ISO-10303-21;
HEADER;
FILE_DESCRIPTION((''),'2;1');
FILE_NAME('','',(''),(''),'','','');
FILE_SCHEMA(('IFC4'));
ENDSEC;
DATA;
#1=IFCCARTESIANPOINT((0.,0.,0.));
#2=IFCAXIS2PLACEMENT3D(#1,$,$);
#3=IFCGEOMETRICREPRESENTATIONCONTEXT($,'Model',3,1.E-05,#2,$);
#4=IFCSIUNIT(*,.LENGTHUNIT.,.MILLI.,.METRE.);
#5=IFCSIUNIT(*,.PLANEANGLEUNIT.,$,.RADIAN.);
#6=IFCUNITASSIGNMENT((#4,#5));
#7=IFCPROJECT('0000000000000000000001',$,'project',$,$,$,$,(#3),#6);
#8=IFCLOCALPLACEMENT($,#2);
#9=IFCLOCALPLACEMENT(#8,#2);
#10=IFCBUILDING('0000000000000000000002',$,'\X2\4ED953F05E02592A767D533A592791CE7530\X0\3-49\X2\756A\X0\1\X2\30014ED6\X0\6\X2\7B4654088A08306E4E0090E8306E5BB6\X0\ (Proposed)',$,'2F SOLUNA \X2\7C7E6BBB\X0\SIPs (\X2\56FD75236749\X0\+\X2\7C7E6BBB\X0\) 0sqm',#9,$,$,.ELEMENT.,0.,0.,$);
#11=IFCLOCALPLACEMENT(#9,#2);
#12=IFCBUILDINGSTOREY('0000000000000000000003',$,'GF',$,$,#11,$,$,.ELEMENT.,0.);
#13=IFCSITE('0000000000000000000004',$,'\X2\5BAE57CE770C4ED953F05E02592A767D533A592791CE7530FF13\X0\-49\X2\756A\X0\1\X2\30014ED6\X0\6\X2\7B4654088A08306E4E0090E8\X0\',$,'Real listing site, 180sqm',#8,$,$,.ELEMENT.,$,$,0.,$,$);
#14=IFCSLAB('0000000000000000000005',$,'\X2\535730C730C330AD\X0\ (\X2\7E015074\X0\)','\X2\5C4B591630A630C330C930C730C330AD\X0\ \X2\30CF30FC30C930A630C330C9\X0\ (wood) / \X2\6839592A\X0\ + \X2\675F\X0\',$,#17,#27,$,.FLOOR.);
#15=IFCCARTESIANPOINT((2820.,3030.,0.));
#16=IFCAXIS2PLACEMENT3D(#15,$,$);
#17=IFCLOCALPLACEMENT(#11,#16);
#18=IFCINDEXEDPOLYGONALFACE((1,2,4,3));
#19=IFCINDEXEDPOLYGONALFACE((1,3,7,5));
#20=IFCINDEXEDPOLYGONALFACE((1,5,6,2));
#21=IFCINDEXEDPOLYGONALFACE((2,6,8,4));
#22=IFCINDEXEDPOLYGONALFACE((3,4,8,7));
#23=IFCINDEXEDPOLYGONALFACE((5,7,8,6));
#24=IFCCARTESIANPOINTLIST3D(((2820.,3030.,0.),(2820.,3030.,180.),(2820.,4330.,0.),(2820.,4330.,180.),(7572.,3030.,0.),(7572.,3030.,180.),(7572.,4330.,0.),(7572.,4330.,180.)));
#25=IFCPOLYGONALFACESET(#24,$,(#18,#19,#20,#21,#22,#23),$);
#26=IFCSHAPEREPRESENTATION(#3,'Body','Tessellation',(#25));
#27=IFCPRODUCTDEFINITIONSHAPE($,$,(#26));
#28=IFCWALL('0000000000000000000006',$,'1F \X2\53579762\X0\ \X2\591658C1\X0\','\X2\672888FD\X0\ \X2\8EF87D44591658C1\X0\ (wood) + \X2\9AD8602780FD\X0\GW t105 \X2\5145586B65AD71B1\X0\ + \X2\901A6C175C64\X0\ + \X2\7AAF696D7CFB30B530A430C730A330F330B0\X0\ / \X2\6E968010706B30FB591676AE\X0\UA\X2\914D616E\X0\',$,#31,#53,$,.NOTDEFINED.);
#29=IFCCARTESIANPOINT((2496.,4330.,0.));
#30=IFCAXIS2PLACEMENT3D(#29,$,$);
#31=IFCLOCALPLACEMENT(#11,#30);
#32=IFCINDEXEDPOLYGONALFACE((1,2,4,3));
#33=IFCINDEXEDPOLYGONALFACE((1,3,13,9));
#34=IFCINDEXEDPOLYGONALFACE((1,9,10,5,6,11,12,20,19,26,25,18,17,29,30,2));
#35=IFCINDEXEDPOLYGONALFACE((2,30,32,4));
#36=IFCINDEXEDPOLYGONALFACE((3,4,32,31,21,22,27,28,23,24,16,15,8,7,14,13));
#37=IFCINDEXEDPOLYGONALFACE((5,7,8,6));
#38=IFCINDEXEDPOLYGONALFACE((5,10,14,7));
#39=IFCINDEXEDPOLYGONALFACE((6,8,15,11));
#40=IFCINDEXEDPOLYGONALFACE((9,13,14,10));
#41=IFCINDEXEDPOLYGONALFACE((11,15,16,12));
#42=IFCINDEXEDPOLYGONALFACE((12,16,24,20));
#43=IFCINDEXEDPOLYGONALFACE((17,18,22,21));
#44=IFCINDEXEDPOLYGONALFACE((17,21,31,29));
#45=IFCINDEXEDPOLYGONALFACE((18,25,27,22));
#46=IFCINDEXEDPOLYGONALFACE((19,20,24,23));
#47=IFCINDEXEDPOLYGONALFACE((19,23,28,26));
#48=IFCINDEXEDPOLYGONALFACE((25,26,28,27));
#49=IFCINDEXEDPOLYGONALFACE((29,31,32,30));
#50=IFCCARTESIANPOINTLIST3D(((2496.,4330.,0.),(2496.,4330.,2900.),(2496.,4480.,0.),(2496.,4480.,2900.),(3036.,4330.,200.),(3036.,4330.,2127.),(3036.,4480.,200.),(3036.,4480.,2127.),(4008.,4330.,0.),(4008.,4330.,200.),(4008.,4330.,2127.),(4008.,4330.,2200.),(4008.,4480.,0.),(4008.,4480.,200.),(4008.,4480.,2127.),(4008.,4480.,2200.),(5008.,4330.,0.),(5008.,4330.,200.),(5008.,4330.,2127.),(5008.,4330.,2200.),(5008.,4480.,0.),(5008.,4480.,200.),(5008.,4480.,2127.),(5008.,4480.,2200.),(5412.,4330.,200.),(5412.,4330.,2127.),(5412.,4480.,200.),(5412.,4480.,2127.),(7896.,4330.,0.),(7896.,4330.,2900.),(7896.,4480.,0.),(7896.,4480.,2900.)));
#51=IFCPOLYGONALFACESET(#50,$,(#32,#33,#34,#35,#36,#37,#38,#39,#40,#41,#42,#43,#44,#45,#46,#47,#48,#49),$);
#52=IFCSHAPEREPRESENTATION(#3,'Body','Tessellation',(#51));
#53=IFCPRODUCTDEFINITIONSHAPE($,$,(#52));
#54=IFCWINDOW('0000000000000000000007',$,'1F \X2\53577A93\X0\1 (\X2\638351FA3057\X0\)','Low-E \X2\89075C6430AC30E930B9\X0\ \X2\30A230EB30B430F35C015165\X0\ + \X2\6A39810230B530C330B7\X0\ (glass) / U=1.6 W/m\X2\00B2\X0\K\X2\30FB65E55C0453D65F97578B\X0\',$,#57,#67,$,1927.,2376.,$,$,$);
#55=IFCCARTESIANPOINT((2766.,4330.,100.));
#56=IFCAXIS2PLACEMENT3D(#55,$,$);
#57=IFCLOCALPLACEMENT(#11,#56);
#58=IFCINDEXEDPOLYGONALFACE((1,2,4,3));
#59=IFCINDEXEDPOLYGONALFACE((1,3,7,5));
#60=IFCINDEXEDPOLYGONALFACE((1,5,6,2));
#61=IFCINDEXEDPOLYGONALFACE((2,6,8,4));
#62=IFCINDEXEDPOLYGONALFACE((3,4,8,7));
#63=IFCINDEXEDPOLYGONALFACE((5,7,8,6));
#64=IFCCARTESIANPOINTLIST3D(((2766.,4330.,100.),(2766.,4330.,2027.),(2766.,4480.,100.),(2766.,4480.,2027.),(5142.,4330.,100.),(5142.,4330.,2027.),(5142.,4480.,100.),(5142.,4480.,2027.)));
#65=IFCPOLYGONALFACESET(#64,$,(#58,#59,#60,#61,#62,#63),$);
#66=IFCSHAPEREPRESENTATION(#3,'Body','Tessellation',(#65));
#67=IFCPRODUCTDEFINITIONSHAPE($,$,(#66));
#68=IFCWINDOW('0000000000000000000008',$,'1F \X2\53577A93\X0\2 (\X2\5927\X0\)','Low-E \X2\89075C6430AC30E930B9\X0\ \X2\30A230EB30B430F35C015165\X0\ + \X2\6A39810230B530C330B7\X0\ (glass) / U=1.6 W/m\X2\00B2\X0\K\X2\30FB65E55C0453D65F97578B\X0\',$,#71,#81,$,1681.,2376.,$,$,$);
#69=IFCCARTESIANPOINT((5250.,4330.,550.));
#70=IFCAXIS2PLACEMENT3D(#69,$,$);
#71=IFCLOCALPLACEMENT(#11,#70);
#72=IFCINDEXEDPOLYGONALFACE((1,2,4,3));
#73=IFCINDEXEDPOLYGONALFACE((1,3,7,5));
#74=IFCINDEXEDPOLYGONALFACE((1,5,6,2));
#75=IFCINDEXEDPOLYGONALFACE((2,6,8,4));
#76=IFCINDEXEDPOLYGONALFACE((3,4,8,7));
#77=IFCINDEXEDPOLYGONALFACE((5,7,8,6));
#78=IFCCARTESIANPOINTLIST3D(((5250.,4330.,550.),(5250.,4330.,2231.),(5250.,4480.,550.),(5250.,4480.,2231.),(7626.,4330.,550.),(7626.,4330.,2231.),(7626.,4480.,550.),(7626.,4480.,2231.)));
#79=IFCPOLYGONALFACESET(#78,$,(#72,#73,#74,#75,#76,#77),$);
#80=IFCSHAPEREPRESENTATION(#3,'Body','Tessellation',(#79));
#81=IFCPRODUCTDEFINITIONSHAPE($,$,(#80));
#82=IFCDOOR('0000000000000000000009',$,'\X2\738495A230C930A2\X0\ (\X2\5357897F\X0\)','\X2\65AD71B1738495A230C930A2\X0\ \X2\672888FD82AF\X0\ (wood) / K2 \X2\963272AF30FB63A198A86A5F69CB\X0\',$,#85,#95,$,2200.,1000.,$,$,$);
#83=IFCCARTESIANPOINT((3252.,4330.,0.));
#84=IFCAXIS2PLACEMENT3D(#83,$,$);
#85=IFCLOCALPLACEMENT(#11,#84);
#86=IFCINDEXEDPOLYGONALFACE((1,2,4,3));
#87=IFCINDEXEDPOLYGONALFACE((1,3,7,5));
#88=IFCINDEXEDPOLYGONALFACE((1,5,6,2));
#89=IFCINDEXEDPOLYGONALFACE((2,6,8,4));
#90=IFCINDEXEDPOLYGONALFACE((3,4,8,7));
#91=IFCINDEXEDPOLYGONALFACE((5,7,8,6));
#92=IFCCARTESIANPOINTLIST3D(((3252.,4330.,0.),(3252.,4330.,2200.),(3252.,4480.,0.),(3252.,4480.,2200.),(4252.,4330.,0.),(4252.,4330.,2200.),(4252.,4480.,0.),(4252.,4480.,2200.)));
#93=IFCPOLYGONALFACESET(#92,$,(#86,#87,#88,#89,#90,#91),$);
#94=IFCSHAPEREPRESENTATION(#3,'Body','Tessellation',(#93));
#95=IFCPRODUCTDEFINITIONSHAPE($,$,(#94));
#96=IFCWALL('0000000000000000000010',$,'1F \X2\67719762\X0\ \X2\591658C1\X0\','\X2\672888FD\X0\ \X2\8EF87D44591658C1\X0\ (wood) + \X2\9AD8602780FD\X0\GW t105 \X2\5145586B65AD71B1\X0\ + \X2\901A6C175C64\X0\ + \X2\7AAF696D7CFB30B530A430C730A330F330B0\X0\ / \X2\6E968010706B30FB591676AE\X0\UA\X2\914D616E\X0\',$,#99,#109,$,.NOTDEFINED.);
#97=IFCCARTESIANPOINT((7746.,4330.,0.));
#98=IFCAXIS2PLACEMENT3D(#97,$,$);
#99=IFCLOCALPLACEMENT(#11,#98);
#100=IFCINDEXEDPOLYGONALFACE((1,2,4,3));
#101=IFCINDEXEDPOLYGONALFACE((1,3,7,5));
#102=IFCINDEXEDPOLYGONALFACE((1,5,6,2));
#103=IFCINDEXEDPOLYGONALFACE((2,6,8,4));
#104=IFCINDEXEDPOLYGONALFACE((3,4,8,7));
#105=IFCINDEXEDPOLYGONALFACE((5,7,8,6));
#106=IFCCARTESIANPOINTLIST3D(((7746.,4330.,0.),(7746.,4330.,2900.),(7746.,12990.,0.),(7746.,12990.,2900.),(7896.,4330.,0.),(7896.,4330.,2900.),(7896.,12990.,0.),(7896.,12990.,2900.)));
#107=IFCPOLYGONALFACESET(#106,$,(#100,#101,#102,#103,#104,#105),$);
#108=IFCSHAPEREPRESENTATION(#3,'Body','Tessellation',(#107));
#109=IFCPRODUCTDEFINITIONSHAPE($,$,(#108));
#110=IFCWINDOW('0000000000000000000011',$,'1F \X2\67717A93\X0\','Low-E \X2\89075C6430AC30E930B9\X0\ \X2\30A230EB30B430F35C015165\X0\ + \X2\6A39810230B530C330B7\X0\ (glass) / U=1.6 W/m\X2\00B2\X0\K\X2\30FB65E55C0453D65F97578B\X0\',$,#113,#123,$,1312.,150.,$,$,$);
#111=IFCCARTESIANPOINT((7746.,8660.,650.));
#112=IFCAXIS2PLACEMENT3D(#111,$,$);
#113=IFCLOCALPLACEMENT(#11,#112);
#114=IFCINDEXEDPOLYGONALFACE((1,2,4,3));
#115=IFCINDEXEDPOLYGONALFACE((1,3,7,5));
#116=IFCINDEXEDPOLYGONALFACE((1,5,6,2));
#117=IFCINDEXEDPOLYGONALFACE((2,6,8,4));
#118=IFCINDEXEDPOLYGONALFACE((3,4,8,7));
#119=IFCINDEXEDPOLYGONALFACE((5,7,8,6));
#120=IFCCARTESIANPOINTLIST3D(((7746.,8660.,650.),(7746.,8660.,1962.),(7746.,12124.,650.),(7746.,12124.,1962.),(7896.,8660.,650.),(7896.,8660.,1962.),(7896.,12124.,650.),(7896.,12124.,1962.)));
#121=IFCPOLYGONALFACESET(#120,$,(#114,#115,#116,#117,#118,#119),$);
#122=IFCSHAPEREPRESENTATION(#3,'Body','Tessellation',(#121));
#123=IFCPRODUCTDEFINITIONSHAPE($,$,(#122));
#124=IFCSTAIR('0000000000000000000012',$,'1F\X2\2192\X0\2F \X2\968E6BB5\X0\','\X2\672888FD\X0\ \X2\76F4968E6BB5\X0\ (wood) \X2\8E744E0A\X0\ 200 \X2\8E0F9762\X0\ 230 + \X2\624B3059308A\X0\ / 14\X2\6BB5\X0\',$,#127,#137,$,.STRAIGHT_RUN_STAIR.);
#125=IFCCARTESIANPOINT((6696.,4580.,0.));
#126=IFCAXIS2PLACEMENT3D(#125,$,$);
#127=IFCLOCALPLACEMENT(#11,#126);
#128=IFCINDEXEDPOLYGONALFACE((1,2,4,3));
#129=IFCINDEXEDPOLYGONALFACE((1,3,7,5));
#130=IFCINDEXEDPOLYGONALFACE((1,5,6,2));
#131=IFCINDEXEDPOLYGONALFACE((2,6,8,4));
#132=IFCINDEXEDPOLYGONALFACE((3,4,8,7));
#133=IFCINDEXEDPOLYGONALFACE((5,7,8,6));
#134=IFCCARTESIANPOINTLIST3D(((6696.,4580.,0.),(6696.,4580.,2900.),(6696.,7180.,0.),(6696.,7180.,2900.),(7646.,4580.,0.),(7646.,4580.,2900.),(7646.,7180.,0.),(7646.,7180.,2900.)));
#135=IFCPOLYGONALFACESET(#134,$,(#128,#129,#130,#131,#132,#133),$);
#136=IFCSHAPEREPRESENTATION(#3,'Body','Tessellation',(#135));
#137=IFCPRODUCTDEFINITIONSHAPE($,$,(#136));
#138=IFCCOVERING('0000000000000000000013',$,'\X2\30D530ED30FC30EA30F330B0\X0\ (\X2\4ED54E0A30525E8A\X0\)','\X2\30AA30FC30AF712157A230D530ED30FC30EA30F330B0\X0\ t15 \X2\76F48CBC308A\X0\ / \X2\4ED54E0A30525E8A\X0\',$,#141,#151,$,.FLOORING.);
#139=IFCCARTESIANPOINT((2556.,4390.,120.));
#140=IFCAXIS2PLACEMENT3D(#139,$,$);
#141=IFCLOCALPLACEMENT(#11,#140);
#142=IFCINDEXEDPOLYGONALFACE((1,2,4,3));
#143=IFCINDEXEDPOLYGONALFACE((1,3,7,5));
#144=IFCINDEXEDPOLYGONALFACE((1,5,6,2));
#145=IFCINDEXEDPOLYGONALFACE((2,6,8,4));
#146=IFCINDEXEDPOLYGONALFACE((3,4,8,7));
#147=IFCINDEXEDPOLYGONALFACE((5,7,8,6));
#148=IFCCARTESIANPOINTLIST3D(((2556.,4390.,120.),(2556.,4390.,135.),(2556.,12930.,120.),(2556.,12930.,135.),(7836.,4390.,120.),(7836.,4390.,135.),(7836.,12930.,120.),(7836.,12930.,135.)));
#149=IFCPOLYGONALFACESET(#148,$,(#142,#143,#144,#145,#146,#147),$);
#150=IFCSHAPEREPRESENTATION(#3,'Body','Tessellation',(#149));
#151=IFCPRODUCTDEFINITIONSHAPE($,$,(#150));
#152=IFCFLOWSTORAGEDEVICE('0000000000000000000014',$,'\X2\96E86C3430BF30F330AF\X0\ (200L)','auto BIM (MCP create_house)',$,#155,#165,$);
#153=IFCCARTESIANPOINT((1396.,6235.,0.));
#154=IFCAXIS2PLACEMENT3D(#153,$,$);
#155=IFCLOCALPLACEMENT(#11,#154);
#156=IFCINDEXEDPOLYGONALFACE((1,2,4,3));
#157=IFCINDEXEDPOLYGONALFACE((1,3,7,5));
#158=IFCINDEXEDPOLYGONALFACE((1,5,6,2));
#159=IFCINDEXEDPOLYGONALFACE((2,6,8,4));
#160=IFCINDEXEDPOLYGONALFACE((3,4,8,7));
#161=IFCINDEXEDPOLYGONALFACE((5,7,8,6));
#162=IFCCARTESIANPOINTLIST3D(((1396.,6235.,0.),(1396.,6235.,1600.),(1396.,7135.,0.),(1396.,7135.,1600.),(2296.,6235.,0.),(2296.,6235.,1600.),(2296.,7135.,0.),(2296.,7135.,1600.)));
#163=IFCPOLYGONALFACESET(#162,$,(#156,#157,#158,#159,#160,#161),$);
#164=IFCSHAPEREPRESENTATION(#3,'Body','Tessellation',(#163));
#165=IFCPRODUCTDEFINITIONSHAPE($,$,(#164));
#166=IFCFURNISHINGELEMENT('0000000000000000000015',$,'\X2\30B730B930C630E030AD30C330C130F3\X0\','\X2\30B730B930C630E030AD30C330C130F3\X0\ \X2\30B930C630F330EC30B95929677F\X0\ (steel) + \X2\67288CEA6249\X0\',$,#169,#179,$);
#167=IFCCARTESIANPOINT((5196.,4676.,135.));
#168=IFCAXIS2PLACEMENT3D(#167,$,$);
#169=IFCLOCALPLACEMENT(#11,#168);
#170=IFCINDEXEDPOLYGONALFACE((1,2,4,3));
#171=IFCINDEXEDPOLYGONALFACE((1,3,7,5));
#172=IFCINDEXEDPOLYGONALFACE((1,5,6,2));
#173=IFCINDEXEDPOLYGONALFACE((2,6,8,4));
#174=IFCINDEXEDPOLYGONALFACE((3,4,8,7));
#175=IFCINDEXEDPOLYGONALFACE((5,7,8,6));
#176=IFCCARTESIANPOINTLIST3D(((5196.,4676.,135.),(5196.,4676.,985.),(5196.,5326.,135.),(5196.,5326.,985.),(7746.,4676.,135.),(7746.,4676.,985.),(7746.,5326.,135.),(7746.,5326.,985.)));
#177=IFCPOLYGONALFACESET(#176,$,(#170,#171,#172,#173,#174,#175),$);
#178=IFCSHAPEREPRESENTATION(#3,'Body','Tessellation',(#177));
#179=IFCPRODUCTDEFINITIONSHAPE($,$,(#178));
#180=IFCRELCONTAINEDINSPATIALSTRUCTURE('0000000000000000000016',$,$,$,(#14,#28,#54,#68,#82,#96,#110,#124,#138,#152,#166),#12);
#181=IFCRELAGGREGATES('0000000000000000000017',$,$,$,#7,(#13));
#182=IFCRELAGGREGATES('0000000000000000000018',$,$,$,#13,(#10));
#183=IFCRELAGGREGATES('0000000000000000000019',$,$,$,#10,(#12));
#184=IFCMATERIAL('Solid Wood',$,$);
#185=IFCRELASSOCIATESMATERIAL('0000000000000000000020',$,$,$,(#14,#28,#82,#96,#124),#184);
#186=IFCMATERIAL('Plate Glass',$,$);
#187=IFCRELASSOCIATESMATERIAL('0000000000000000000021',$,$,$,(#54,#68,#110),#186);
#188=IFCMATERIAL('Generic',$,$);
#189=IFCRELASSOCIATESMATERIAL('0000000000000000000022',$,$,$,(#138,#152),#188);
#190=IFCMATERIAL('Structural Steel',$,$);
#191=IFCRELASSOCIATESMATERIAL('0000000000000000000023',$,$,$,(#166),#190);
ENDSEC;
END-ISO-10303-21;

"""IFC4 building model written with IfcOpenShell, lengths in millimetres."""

from ifc_helpers import new_model, si_unit, frame, frame_2d, origin, place, context, project, spatial, rectangle, extrude, material, element, fill, save


model = new_model("IFC4")

# Units and contexts
model_context = context("Model", 3, precision=1e-05, world=origin())
ifc_project = project(units=[si_unit("LENGTHUNIT", "METRE", prefix="MILLI"), si_unit("PLANEANGLEUNIT", "RADIAN")], contexts=[model_context])

# Site, building, storey
site_placement = place(None, origin())
site = spatial("IfcSite", under=ifc_project, at=site_placement, Name="宮城県仙台市太白区大野田３-49番1、他6筆合計の一部", ObjectType="Real listing site, 180sqm", CompositionType="ELEMENT", RefElevation=0.0)
building_placement = place(site_placement, origin())
building = spatial("IfcBuilding", under=site, at=building_placement, Name="仙台市太白区大野田3-49番1、他6筆合計の一部の家 (Proposed)", ObjectType="2F SOLUNA 籾殻SIPs (国産杉+籾殻) 0sqm", CompositionType="ELEMENT", ElevationOfRefHeight=0.0, ElevationOfTerrain=0.0)
storey_placement = place(building_placement, origin())
storey = spatial("IfcBuildingStorey", under=building, at=storey_placement, Name="GF", CompositionType="ELEMENT", Elevation=0.0)

# Slab
ifc_material_1 = material(Name="Solid Wood")
slab_1_placement = place(storey_placement, frame((2820.0, 3030.0, 0.0)))
element("IfcSlab", 1, at=slab_1_placement, inside=storey, material=ifc_material_1, Name="南デッキ (縁側)", Description="屋外ウッドデッキ ハードウッド (wood) / 根太 + 束", PredefinedType="FLOOR", context=model_context, shape_type="SweptSolid", body=[
    extrude(rectangle(XDim=4752.0, YDim=1300.0, at=frame_2d((2376.0, 650.0))), frame((2820.0, 3030.0, 0.0)), (0.0, 0.0, 1.0), 180.0),
])

# Wall, openings, windows, door
wall_1_placement = place(storey_placement, frame((2496.0, 4330.0, 0.0)))
wall_1 = element("IfcWall", 2, at=wall_1_placement, inside=storey, material=ifc_material_1, Name="1F 南面 外壁", Description="木製 軸組外壁 (wood) + 高性能GW t105 充填断熱 + 通気層 + 窯業系サイディング / 準耐火・外皮UA配慮", PredefinedType="NOTDEFINED", context=model_context, shape_type="SweptSolid", body=[
    extrude(rectangle(XDim=5400.0, YDim=150.0, at=frame_2d((2700.0, 75.0))), frame((2496.0, 4330.0, 0.0)), (0.0, 0.0, 1.0), 2900.0),
])
opening_1_placement = place(storey_placement, frame((2766.0, 4330.0, 100.0)))
opening_1 = element("IfcOpeningElement", 3, at=opening_1_placement, cuts=wall_1, PredefinedType="NOTDEFINED", context=model_context, shape_type="SweptSolid", body=[
    extrude(rectangle(XDim=2376.0, YDim=150.0, at=frame_2d((1188.0, 75.0))), frame((2766.0, 4330.0, 100.0)), (0.0, 0.0, 1.0), 1927.0),
])
opening_2_placement = place(storey_placement, frame((5250.0, 4330.0, 550.0)))
opening_2 = element("IfcOpeningElement", 4, at=opening_2_placement, cuts=wall_1, PredefinedType="NOTDEFINED", context=model_context, shape_type="SweptSolid", body=[
    extrude(rectangle(XDim=2376.0, YDim=150.0, at=frame_2d((1188.0, 75.0))), frame((5250.0, 4330.0, 550.0)), (0.0, 0.0, 1.0), 1681.0),
])
opening_3_placement = place(storey_placement, frame((3252.0, 4330.0, 0.0)))
opening_3 = element("IfcOpeningElement", 5, at=opening_3_placement, cuts=wall_1, PredefinedType="NOTDEFINED", context=model_context, shape_type="SweptSolid", body=[
    extrude(rectangle(XDim=1000.0, YDim=150.0, at=frame_2d((500.0, 75.0))), frame((3252.0, 4330.0, 0.0)), (0.0, 0.0, 1.0), 2200.0),
])
ifc_material_2 = material(Name="Plate Glass")
window_1_placement = place(storey_placement, frame((2766.0, 4330.0, 100.0)))
window_1 = element("IfcWindow", 6, at=window_1_placement, inside=storey, material=ifc_material_2, Name="1F 南窓1 (掃出し)", Description="Low-E 複層ガラス アルゴン封入 + 樹脂サッシ (glass) / U=1.6 W/m²K・日射取得型", OverallHeight=1927.0, OverallWidth=2376.0, context=model_context, shape_type="SweptSolid", body=[
    extrude(rectangle(XDim=2376.0, YDim=150.0, at=frame_2d((1188.0, 75.0))), frame((2766.0, 4330.0, 100.0)), (0.0, 0.0, 1.0), 1927.0),
])
fill(opening_1, window_1)
window_2_placement = place(storey_placement, frame((5250.0, 4330.0, 550.0)))
window_2 = element("IfcWindow", 7, at=window_2_placement, inside=storey, material=ifc_material_2, Name="1F 南窓2 (大)", Description="Low-E 複層ガラス アルゴン封入 + 樹脂サッシ (glass) / U=1.6 W/m²K・日射取得型", OverallHeight=1681.0, OverallWidth=2376.0, context=model_context, shape_type="SweptSolid", body=[
    extrude(rectangle(XDim=2376.0, YDim=150.0, at=frame_2d((1188.0, 75.0))), frame((5250.0, 4330.0, 550.0)), (0.0, 0.0, 1.0), 1681.0),
])
fill(opening_2, window_2)
door_placement = place(storey_placement, frame((3252.0, 4330.0, 0.0)))
door = element("IfcDoor", 8, at=door_placement, inside=storey, material=ifc_material_1, Name="玄関ドア (南西)", Description="断熱玄関ドア 木製芯 (wood) / K2 防犯・採風機構", OverallHeight=2200.0, OverallWidth=1000.0, context=model_context, shape_type="SweptSolid", body=[
    extrude(rectangle(XDim=1000.0, YDim=150.0, at=frame_2d((500.0, 75.0))), frame((3252.0, 4330.0, 0.0)), (0.0, 0.0, 1.0), 2200.0),
])
fill(opening_3, door)

# Wall, opening, window
wall_2_placement = place(storey_placement, frame((7746.0, 4330.0, 0.0)))
wall_2 = element("IfcWall", 9, at=wall_2_placement, inside=storey, material=ifc_material_1, Name="1F 東面 外壁", Description="木製 軸組外壁 (wood) + 高性能GW t105 充填断熱 + 通気層 + 窯業系サイディング / 準耐火・外皮UA配慮", PredefinedType="NOTDEFINED", context=model_context, shape_type="SweptSolid", body=[
    extrude(rectangle(XDim=150.0, YDim=8660.0, at=frame_2d((75.0, 4330.0))), frame((7746.0, 4330.0, 0.0)), (0.0, 0.0, 1.0), 2900.0),
])
opening_4_placement = place(storey_placement, frame((7746.0, 8660.0, 650.0)))
opening_4 = element("IfcOpeningElement", 10, at=opening_4_placement, cuts=wall_2, PredefinedType="NOTDEFINED", context=model_context, shape_type="SweptSolid", body=[
    extrude(rectangle(XDim=150.0, YDim=3464.0, at=frame_2d((75.0, 1732.0))), frame((7746.0, 8660.0, 650.0)), (0.0, 0.0, 1.0), 1312.0),
])
window_3_placement = place(storey_placement, frame((7746.0, 8660.0, 650.0)))
window_3 = element("IfcWindow", 11, at=window_3_placement, inside=storey, material=ifc_material_2, Name="1F 東窓", Description="Low-E 複層ガラス アルゴン封入 + 樹脂サッシ (glass) / U=1.6 W/m²K・日射取得型", OverallHeight=1312.0, OverallWidth=150.0, context=model_context, shape_type="SweptSolid", body=[
    extrude(rectangle(XDim=150.0, YDim=3464.0, at=frame_2d((75.0, 1732.0))), frame((7746.0, 8660.0, 650.0)), (0.0, 0.0, 1.0), 1312.0),
])
fill(opening_4, window_3)

# Stair
stair_placement = place(storey_placement, frame((6696.0, 4580.0, 0.0)))
element("IfcStair", 12, at=stair_placement, inside=storey, material=ifc_material_1, Name="1F→2F 階段", Description="木製 直階段 (wood) 蹴上 200 踏面 230 + 手すり / 14段", PredefinedType="STRAIGHT_RUN_STAIR", context=model_context, shape_type="SweptSolid", body=[
    extrude(rectangle(XDim=950.0, YDim=2600.0, at=frame_2d((475.0, 1300.0))), frame((6696.0, 4580.0, 0.0)), (0.0, 0.0, 1.0), 2900.0),
])

# Covering
ifc_material_3 = material(Name="Generic")
covering_placement = place(storey_placement, frame((2556.0, 4390.0, 120.0)))
element("IfcCovering", 13, at=covering_placement, inside=storey, material=ifc_material_3, Name="フローリング (仕上げ床)", Description="オーク無垢フローリング t15 直貼り / 仕上げ床", PredefinedType="FLOORING", context=model_context, shape_type="SweptSolid", body=[
    extrude(rectangle(XDim=5280.0, YDim=8540.0, at=frame_2d((2640.0, 4270.0))), frame((2556.0, 4390.0, 120.0)), (0.0, 0.0, 1.0), 15.0),
])

# Flow storage device
flow_storage_device_placement = place(storey_placement, frame((1396.0, 6235.0, 0.0)))
element("IfcFlowStorageDevice", 14, at=flow_storage_device_placement, inside=storey, material=ifc_material_3, Name="雨水タンク (200L)", Description="auto BIM (MCP create_house)", context=model_context, shape_type="SweptSolid", body=[
    extrude(rectangle(XDim=900.0, YDim=900.0, at=frame_2d((450.0, 450.0))), frame((1396.0, 6235.0, 0.0)), (0.0, 0.0, 1.0), 1600.0),
])

# Furnishing element
ifc_material_4 = material(Name="Structural Steel")
furnishing_placement = place(storey_placement, frame((5196.0, 4676.0, 135.0)))
element("IfcFurnishingElement", 15, at=furnishing_placement, inside=storey, material=ifc_material_4, Name="システムキッチン", Description="システムキッチン ステンレス天板 (steel) + 木質扉", context=model_context, shape_type="SweptSolid", body=[
    extrude(rectangle(XDim=2550.0, YDim=650.0, at=frame_2d((1275.0, 325.0))), frame((5196.0, 4676.0, 135.0)), (0.0, 0.0, 1.0), 850.0),
])

save(model, "model.ifc")
